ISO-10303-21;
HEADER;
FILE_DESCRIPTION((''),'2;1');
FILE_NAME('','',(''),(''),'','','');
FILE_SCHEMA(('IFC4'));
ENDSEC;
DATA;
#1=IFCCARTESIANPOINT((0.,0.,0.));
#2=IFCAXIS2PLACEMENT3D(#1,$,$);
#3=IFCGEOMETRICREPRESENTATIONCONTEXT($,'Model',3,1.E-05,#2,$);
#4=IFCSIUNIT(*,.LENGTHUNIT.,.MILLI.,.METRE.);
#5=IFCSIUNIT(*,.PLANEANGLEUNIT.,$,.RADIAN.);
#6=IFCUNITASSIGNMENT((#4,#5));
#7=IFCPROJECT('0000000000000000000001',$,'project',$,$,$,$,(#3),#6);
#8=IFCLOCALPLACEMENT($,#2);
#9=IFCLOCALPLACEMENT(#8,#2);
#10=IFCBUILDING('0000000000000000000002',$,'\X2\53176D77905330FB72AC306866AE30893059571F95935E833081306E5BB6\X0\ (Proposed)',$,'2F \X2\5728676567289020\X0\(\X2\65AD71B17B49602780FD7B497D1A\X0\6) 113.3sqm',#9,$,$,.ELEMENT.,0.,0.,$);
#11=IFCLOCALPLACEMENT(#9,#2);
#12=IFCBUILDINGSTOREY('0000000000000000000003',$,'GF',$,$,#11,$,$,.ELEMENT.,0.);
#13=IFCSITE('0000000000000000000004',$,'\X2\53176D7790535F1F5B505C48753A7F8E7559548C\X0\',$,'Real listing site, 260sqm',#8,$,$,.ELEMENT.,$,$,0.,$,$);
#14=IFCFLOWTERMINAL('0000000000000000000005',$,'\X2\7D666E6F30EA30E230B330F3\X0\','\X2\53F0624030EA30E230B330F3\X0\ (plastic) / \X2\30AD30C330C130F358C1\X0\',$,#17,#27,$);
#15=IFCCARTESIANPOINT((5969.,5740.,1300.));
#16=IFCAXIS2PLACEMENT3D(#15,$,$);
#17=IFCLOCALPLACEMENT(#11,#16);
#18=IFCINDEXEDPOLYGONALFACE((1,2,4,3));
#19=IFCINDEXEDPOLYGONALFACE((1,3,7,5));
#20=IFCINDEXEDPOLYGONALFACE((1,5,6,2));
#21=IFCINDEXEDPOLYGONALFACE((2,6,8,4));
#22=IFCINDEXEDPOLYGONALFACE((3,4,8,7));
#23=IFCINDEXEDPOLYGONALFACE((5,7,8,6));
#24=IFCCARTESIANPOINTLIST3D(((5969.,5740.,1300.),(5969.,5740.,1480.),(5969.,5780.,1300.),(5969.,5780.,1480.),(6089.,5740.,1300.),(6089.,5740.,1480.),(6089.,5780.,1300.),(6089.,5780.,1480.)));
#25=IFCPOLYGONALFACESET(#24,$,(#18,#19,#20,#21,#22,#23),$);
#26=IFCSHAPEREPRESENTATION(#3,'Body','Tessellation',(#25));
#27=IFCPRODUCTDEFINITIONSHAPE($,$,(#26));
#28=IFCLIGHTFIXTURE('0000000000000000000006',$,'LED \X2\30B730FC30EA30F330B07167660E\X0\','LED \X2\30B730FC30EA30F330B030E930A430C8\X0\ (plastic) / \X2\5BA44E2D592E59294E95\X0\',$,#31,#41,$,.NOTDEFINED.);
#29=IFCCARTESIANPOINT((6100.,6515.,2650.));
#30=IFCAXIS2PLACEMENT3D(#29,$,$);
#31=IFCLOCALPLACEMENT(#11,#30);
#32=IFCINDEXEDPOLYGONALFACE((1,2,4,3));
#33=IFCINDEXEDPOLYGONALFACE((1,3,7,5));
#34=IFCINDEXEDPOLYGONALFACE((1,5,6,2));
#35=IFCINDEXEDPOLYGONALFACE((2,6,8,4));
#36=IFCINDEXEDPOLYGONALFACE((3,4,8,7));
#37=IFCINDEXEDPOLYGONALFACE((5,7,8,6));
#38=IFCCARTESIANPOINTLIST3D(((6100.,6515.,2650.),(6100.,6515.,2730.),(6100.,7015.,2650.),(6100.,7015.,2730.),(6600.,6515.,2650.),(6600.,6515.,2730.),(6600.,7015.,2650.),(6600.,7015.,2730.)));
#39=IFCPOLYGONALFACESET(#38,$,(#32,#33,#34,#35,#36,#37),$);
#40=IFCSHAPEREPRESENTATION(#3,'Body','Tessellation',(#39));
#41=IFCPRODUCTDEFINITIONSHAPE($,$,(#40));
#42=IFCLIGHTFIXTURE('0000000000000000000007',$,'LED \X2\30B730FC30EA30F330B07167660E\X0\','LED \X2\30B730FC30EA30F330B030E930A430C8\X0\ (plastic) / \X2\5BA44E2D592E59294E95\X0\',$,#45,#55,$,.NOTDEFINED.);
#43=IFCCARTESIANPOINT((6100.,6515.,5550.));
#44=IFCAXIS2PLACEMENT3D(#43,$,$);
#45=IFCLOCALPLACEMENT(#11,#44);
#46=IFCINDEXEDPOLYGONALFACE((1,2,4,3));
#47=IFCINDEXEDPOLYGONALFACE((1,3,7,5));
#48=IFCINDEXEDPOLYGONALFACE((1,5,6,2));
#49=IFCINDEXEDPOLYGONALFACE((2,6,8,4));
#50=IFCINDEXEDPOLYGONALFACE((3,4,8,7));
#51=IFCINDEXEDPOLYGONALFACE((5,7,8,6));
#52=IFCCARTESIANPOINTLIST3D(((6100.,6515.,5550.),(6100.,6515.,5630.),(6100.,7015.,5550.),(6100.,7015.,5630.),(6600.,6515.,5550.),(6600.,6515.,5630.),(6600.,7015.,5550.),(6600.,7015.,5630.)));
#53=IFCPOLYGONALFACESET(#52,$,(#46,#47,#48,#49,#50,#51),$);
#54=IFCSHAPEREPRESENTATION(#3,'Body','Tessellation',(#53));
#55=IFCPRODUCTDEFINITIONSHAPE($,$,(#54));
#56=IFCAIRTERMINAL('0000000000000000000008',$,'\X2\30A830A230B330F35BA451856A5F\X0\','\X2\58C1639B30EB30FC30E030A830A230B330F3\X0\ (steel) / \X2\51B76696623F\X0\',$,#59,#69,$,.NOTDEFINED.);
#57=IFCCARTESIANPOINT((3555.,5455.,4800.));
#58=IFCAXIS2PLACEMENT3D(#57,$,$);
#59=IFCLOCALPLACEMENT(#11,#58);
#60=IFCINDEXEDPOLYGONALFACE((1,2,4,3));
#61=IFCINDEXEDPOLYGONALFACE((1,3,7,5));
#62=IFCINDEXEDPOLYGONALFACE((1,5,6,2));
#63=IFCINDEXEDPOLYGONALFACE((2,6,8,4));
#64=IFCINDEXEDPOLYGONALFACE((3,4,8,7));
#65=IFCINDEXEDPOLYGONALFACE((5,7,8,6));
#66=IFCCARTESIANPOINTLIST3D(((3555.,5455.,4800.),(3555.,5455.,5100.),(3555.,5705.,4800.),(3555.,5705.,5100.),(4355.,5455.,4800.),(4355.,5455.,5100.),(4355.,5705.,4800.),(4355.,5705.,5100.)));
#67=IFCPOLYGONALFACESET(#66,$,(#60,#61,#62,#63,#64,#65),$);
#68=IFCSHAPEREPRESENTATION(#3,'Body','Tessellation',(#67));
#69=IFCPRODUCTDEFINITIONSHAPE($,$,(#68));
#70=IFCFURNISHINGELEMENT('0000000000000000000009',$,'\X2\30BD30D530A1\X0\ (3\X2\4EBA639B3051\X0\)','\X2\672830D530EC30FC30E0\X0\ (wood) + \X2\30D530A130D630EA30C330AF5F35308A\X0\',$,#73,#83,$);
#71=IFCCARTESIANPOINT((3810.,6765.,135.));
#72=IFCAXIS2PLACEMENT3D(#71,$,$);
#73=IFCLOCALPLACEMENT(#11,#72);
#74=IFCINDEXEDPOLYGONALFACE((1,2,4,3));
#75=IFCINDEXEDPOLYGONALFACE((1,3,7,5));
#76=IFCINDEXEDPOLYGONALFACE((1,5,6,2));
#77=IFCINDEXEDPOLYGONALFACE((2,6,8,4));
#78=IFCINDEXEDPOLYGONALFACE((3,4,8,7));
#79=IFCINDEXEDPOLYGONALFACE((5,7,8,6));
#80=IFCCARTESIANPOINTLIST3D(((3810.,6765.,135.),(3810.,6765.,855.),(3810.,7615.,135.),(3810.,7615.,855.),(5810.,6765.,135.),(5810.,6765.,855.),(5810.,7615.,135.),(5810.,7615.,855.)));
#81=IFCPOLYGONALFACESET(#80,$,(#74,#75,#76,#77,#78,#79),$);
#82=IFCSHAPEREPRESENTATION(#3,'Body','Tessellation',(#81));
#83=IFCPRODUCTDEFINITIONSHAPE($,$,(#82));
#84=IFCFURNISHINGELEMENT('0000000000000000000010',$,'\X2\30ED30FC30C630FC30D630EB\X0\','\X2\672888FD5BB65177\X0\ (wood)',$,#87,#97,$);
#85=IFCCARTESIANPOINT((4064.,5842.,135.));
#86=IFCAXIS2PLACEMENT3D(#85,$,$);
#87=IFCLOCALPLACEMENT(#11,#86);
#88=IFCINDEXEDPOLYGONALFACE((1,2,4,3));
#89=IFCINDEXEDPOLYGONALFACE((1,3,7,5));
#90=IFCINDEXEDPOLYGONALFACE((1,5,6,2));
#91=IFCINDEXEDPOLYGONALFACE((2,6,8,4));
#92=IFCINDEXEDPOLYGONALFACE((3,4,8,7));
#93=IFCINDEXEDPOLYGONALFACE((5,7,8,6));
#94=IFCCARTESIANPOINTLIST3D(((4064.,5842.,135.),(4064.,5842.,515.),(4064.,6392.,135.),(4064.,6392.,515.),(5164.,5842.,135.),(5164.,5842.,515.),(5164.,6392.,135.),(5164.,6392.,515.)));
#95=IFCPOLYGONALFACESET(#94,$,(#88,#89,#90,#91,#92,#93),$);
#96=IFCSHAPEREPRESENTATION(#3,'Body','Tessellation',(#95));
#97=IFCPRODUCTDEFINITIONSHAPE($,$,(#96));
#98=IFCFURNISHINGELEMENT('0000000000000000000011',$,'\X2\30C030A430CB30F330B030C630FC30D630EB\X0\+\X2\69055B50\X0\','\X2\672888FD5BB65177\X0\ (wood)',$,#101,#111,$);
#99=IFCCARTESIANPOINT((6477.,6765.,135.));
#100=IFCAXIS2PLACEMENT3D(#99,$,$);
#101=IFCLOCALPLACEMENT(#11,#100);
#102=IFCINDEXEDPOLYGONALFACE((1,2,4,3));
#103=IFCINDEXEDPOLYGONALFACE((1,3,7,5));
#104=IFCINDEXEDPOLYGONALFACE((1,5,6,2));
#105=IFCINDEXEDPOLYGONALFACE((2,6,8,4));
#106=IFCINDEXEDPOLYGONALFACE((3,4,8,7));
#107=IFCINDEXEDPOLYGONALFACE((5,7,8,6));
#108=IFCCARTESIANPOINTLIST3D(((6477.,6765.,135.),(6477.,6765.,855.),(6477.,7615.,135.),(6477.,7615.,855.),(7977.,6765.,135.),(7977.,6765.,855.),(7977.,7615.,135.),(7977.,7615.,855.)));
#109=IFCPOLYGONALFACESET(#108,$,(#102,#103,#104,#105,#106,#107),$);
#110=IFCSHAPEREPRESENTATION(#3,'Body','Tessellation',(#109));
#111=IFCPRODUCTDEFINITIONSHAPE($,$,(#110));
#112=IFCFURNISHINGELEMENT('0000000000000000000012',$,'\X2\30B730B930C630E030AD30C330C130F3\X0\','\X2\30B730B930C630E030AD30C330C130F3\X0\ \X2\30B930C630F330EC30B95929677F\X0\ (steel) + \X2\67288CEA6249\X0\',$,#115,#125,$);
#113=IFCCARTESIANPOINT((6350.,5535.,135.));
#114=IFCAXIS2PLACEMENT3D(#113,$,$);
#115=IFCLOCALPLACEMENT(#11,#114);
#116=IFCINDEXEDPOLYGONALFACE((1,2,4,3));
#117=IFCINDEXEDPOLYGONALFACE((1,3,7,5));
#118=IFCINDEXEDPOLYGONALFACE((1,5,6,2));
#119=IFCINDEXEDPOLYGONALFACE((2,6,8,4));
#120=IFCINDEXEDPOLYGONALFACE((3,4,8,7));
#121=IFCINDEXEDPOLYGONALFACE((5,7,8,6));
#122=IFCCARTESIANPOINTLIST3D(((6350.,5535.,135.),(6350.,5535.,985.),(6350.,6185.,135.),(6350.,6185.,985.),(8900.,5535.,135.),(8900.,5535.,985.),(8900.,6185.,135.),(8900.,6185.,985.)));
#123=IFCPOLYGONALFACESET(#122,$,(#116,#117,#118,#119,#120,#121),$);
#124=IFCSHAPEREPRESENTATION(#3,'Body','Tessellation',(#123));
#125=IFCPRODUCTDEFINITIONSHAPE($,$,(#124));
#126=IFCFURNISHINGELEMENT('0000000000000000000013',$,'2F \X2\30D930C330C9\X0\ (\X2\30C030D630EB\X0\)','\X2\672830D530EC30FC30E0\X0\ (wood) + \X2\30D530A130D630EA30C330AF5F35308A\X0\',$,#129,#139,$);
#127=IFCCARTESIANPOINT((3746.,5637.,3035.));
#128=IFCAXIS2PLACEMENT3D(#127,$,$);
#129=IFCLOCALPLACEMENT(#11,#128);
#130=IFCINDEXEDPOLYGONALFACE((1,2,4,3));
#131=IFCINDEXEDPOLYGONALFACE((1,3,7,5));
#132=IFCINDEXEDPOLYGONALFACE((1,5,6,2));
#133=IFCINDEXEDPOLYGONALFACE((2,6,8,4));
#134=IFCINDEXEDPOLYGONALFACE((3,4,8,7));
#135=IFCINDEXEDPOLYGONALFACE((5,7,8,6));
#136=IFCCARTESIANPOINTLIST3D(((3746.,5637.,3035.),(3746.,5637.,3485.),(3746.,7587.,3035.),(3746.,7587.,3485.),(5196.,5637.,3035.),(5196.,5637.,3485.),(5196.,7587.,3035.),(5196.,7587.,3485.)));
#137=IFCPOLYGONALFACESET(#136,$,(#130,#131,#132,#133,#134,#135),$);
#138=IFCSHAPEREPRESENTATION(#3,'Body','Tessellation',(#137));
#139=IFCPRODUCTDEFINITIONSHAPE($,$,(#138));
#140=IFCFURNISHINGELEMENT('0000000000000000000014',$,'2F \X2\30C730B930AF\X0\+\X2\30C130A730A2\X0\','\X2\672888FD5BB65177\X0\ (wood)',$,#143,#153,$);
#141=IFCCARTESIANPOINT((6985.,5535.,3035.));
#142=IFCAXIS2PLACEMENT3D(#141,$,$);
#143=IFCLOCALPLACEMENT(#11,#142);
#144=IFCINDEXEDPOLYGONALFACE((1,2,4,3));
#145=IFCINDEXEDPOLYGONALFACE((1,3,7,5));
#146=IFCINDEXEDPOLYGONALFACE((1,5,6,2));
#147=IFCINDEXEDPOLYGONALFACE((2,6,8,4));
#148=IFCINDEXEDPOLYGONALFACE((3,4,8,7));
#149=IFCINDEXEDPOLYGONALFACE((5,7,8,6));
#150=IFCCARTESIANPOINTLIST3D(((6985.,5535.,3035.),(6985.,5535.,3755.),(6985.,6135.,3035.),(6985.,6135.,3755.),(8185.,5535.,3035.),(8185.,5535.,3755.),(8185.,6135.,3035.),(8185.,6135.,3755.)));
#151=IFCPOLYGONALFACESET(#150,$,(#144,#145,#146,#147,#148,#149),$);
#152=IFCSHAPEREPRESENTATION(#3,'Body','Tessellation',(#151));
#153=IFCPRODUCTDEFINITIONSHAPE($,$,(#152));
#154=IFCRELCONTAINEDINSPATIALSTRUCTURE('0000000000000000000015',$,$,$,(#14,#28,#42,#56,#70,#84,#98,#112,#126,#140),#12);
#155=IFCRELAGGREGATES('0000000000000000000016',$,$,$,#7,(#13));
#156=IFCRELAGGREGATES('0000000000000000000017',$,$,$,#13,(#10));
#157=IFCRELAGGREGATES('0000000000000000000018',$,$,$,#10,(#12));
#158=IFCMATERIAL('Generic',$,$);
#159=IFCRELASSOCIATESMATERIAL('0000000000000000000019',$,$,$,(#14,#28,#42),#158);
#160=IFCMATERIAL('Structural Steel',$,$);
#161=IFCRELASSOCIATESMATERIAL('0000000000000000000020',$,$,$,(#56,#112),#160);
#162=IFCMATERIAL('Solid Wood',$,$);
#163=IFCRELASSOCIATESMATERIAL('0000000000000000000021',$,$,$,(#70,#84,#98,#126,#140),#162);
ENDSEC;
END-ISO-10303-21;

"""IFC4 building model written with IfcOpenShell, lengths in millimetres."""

from ifc_helpers import new_model, si_unit, frame, frame_2d, origin, place, context, project, spatial, rectangle, extrude, material, element, save


model = new_model("IFC4")

# Units and contexts
model_context = context("Model", 3, precision=1e-05, world=origin())
ifc_project = project(units=[si_unit("LENGTHUNIT", "METRE", prefix="MILLI"), si_unit("PLANEANGLEUNIT", "RADIAN")], contexts=[model_context])

# Site, building, storey
site_placement = place(None, origin())
site = spatial("IfcSite", under=ifc_project, at=site_placement, Name="北海道弟子屈町美留和", ObjectType="Real listing site, 260sqm", CompositionType="ELEMENT", RefElevation=0.0)
building_placement = place(site_placement, origin())
building = spatial("IfcBuilding", under=site, at=building_placement, Name="北海道・犬と暮らす土間広めの家 (Proposed)", ObjectType="2F 在来木造(断熱等性能等級6) 113.3sqm", CompositionType="ELEMENT", ElevationOfRefHeight=0.0, ElevationOfTerrain=0.0)
storey_placement = place(building_placement, origin())
storey = spatial("IfcBuildingStorey", under=building, at=storey_placement, Name="GF", CompositionType="ELEMENT", Elevation=0.0)

# Shared definitions
ifc_material_1 = material(Name="Solid Wood")

# Shared definitions
ifc_material_2 = material(Name="Generic")

# Shared definitions
ifc_material_3 = material(Name="Structural Steel")

# Flow terminal
flow_terminal_1_placement = place(storey_placement, frame((5969.0, 5740.0, 1300.0)))
element("IfcFlowTerminal", 1, at=flow_terminal_1_placement, inside=storey, material=ifc_material_2, Name="給湯リモコン", Description="台所リモコン (plastic) / キッチン壁", context=model_context, shape_type="SweptSolid", body=[
    extrude(rectangle(XDim=120.0, YDim=40.0, at=frame_2d((60.0, 20.0))), frame((5969.0, 5740.0, 1300.0)), (0.0, 0.0, 1.0), 180.0),
])

# Light fixtures
light_fixture_1_placement = place(storey_placement, frame((6100.0, 6515.0, 2650.0)))
element("IfcLightFixture", 2, at=light_fixture_1_placement, inside=storey, material=ifc_material_2, Name="LED シーリング照明", Description="LED シーリングライト (plastic) / 室中央天井", PredefinedType="NOTDEFINED", context=model_context, shape_type="SweptSolid", body=[
    extrude(rectangle(XDim=500.0, YDim=500.0, at=frame_2d((250.0, 250.0))), frame((6100.0, 6515.0, 2650.0)), (0.0, 0.0, 1.0), 80.0),
])
light_fixture_2_placement = place(storey_placement, frame((6100.0, 6515.0, 5550.0)))
element("IfcLightFixture", 3, at=light_fixture_2_placement, inside=storey, material=ifc_material_2, Name="LED シーリング照明", Description="LED シーリングライト (plastic) / 室中央天井", PredefinedType="NOTDEFINED", context=model_context, shape_type="SweptSolid", body=[
    extrude(rectangle(XDim=500.0, YDim=500.0, at=frame_2d((250.0, 250.0))), frame((6100.0, 6515.0, 5550.0)), (0.0, 0.0, 1.0), 80.0),
])

# Air terminal
air_terminal_placement = place(storey_placement, frame((3555.0, 5455.0, 4800.0)))
element("IfcAirTerminal", 4, at=air_terminal_placement, inside=storey, material=ifc_material_3, Name="エアコン室内機", Description="壁掛ルームエアコン (steel) / 冷暖房", PredefinedType="NOTDEFINED", context=model_context, shape_type="SweptSolid", body=[
    extrude(rectangle(XDim=800.0, YDim=250.0, at=frame_2d((400.0, 125.0))), frame((3555.0, 5455.0, 4800.0)), (0.0, 0.0, 1.0), 300.0),
])

# Furnishing elements
furnishing_1_placement = place(storey_placement, frame((3810.0, 6765.0, 135.0)))
element("IfcFurnishingElement", 5, at=furnishing_1_placement, inside=storey, material=ifc_material_1, Name="ソファ (3人掛け)", Description="木フレーム (wood) + ファブリック張り", context=model_context, shape_type="SweptSolid", body=[
    extrude(rectangle(XDim=2000.0, YDim=850.0, at=frame_2d((1000.0, 425.0))), frame((3810.0, 6765.0, 135.0)), (0.0, 0.0, 1.0), 720.0),
])
furnishing_2_placement = place(storey_placement, frame((4064.0, 5842.0, 135.0)))
element("IfcFurnishingElement", 6, at=furnishing_2_placement, inside=storey, material=ifc_material_1, Name="ローテーブル", Description="木製家具 (wood)", context=model_context, shape_type="SweptSolid", body=[
    extrude(rectangle(XDim=1100.0, YDim=550.0, at=frame_2d((550.0, 275.0))), frame((4064.0, 5842.0, 135.0)), (0.0, 0.0, 1.0), 380.0),
])
furnishing_3_placement = place(storey_placement, frame((6477.0, 6765.0, 135.0)))
element("IfcFurnishingElement", 7, at=furnishing_3_placement, inside=storey, material=ifc_material_1, Name="ダイニングテーブル+椅子", Description="木製家具 (wood)", context=model_context, shape_type="SweptSolid", body=[
    extrude(rectangle(XDim=1500.0, YDim=850.0, at=frame_2d((750.0, 425.0))), frame((6477.0, 6765.0, 135.0)), (0.0, 0.0, 1.0), 720.0),
])
furnishing_4_placement = place(storey_placement, frame((6350.0, 5535.0, 135.0)))
element("IfcFurnishingElement", 8, at=furnishing_4_placement, inside=storey, material=ifc_material_3, Name="システムキッチン", Description="システムキッチン ステンレス天板 (steel) + 木質扉", context=model_context, shape_type="SweptSolid", body=[
    extrude(rectangle(XDim=2550.0, YDim=650.0, at=frame_2d((1275.0, 325.0))), frame((6350.0, 5535.0, 135.0)), (0.0, 0.0, 1.0), 850.0),
])
furnishing_5_placement = place(storey_placement, frame((3746.0, 5637.0, 3035.0)))
element("IfcFurnishingElement", 9, at=furnishing_5_placement, inside=storey, material=ifc_material_1, Name="2F ベッド (ダブル)", Description="木フレーム (wood) + ファブリック張り", context=model_context, shape_type="SweptSolid", body=[
    extrude(rectangle(XDim=1450.0, YDim=1950.0, at=frame_2d((725.0, 975.0))), frame((3746.0, 5637.0, 3035.0)), (0.0, 0.0, 1.0), 450.0),
])
furnishing_6_placement = place(storey_placement, frame((6985.0, 5535.0, 3035.0)))
element("IfcFurnishingElement", 10, at=furnishing_6_placement, inside=storey, material=ifc_material_1, Name="2F デスク+チェア", Description="木製家具 (wood)", context=model_context, shape_type="SweptSolid", body=[
    extrude(rectangle(XDim=1200.0, YDim=600.0, at=frame_2d((600.0, 300.0))), frame((6985.0, 5535.0, 3035.0)), (0.0, 0.0, 1.0), 720.0),
])

save(model, "model.ifc")
